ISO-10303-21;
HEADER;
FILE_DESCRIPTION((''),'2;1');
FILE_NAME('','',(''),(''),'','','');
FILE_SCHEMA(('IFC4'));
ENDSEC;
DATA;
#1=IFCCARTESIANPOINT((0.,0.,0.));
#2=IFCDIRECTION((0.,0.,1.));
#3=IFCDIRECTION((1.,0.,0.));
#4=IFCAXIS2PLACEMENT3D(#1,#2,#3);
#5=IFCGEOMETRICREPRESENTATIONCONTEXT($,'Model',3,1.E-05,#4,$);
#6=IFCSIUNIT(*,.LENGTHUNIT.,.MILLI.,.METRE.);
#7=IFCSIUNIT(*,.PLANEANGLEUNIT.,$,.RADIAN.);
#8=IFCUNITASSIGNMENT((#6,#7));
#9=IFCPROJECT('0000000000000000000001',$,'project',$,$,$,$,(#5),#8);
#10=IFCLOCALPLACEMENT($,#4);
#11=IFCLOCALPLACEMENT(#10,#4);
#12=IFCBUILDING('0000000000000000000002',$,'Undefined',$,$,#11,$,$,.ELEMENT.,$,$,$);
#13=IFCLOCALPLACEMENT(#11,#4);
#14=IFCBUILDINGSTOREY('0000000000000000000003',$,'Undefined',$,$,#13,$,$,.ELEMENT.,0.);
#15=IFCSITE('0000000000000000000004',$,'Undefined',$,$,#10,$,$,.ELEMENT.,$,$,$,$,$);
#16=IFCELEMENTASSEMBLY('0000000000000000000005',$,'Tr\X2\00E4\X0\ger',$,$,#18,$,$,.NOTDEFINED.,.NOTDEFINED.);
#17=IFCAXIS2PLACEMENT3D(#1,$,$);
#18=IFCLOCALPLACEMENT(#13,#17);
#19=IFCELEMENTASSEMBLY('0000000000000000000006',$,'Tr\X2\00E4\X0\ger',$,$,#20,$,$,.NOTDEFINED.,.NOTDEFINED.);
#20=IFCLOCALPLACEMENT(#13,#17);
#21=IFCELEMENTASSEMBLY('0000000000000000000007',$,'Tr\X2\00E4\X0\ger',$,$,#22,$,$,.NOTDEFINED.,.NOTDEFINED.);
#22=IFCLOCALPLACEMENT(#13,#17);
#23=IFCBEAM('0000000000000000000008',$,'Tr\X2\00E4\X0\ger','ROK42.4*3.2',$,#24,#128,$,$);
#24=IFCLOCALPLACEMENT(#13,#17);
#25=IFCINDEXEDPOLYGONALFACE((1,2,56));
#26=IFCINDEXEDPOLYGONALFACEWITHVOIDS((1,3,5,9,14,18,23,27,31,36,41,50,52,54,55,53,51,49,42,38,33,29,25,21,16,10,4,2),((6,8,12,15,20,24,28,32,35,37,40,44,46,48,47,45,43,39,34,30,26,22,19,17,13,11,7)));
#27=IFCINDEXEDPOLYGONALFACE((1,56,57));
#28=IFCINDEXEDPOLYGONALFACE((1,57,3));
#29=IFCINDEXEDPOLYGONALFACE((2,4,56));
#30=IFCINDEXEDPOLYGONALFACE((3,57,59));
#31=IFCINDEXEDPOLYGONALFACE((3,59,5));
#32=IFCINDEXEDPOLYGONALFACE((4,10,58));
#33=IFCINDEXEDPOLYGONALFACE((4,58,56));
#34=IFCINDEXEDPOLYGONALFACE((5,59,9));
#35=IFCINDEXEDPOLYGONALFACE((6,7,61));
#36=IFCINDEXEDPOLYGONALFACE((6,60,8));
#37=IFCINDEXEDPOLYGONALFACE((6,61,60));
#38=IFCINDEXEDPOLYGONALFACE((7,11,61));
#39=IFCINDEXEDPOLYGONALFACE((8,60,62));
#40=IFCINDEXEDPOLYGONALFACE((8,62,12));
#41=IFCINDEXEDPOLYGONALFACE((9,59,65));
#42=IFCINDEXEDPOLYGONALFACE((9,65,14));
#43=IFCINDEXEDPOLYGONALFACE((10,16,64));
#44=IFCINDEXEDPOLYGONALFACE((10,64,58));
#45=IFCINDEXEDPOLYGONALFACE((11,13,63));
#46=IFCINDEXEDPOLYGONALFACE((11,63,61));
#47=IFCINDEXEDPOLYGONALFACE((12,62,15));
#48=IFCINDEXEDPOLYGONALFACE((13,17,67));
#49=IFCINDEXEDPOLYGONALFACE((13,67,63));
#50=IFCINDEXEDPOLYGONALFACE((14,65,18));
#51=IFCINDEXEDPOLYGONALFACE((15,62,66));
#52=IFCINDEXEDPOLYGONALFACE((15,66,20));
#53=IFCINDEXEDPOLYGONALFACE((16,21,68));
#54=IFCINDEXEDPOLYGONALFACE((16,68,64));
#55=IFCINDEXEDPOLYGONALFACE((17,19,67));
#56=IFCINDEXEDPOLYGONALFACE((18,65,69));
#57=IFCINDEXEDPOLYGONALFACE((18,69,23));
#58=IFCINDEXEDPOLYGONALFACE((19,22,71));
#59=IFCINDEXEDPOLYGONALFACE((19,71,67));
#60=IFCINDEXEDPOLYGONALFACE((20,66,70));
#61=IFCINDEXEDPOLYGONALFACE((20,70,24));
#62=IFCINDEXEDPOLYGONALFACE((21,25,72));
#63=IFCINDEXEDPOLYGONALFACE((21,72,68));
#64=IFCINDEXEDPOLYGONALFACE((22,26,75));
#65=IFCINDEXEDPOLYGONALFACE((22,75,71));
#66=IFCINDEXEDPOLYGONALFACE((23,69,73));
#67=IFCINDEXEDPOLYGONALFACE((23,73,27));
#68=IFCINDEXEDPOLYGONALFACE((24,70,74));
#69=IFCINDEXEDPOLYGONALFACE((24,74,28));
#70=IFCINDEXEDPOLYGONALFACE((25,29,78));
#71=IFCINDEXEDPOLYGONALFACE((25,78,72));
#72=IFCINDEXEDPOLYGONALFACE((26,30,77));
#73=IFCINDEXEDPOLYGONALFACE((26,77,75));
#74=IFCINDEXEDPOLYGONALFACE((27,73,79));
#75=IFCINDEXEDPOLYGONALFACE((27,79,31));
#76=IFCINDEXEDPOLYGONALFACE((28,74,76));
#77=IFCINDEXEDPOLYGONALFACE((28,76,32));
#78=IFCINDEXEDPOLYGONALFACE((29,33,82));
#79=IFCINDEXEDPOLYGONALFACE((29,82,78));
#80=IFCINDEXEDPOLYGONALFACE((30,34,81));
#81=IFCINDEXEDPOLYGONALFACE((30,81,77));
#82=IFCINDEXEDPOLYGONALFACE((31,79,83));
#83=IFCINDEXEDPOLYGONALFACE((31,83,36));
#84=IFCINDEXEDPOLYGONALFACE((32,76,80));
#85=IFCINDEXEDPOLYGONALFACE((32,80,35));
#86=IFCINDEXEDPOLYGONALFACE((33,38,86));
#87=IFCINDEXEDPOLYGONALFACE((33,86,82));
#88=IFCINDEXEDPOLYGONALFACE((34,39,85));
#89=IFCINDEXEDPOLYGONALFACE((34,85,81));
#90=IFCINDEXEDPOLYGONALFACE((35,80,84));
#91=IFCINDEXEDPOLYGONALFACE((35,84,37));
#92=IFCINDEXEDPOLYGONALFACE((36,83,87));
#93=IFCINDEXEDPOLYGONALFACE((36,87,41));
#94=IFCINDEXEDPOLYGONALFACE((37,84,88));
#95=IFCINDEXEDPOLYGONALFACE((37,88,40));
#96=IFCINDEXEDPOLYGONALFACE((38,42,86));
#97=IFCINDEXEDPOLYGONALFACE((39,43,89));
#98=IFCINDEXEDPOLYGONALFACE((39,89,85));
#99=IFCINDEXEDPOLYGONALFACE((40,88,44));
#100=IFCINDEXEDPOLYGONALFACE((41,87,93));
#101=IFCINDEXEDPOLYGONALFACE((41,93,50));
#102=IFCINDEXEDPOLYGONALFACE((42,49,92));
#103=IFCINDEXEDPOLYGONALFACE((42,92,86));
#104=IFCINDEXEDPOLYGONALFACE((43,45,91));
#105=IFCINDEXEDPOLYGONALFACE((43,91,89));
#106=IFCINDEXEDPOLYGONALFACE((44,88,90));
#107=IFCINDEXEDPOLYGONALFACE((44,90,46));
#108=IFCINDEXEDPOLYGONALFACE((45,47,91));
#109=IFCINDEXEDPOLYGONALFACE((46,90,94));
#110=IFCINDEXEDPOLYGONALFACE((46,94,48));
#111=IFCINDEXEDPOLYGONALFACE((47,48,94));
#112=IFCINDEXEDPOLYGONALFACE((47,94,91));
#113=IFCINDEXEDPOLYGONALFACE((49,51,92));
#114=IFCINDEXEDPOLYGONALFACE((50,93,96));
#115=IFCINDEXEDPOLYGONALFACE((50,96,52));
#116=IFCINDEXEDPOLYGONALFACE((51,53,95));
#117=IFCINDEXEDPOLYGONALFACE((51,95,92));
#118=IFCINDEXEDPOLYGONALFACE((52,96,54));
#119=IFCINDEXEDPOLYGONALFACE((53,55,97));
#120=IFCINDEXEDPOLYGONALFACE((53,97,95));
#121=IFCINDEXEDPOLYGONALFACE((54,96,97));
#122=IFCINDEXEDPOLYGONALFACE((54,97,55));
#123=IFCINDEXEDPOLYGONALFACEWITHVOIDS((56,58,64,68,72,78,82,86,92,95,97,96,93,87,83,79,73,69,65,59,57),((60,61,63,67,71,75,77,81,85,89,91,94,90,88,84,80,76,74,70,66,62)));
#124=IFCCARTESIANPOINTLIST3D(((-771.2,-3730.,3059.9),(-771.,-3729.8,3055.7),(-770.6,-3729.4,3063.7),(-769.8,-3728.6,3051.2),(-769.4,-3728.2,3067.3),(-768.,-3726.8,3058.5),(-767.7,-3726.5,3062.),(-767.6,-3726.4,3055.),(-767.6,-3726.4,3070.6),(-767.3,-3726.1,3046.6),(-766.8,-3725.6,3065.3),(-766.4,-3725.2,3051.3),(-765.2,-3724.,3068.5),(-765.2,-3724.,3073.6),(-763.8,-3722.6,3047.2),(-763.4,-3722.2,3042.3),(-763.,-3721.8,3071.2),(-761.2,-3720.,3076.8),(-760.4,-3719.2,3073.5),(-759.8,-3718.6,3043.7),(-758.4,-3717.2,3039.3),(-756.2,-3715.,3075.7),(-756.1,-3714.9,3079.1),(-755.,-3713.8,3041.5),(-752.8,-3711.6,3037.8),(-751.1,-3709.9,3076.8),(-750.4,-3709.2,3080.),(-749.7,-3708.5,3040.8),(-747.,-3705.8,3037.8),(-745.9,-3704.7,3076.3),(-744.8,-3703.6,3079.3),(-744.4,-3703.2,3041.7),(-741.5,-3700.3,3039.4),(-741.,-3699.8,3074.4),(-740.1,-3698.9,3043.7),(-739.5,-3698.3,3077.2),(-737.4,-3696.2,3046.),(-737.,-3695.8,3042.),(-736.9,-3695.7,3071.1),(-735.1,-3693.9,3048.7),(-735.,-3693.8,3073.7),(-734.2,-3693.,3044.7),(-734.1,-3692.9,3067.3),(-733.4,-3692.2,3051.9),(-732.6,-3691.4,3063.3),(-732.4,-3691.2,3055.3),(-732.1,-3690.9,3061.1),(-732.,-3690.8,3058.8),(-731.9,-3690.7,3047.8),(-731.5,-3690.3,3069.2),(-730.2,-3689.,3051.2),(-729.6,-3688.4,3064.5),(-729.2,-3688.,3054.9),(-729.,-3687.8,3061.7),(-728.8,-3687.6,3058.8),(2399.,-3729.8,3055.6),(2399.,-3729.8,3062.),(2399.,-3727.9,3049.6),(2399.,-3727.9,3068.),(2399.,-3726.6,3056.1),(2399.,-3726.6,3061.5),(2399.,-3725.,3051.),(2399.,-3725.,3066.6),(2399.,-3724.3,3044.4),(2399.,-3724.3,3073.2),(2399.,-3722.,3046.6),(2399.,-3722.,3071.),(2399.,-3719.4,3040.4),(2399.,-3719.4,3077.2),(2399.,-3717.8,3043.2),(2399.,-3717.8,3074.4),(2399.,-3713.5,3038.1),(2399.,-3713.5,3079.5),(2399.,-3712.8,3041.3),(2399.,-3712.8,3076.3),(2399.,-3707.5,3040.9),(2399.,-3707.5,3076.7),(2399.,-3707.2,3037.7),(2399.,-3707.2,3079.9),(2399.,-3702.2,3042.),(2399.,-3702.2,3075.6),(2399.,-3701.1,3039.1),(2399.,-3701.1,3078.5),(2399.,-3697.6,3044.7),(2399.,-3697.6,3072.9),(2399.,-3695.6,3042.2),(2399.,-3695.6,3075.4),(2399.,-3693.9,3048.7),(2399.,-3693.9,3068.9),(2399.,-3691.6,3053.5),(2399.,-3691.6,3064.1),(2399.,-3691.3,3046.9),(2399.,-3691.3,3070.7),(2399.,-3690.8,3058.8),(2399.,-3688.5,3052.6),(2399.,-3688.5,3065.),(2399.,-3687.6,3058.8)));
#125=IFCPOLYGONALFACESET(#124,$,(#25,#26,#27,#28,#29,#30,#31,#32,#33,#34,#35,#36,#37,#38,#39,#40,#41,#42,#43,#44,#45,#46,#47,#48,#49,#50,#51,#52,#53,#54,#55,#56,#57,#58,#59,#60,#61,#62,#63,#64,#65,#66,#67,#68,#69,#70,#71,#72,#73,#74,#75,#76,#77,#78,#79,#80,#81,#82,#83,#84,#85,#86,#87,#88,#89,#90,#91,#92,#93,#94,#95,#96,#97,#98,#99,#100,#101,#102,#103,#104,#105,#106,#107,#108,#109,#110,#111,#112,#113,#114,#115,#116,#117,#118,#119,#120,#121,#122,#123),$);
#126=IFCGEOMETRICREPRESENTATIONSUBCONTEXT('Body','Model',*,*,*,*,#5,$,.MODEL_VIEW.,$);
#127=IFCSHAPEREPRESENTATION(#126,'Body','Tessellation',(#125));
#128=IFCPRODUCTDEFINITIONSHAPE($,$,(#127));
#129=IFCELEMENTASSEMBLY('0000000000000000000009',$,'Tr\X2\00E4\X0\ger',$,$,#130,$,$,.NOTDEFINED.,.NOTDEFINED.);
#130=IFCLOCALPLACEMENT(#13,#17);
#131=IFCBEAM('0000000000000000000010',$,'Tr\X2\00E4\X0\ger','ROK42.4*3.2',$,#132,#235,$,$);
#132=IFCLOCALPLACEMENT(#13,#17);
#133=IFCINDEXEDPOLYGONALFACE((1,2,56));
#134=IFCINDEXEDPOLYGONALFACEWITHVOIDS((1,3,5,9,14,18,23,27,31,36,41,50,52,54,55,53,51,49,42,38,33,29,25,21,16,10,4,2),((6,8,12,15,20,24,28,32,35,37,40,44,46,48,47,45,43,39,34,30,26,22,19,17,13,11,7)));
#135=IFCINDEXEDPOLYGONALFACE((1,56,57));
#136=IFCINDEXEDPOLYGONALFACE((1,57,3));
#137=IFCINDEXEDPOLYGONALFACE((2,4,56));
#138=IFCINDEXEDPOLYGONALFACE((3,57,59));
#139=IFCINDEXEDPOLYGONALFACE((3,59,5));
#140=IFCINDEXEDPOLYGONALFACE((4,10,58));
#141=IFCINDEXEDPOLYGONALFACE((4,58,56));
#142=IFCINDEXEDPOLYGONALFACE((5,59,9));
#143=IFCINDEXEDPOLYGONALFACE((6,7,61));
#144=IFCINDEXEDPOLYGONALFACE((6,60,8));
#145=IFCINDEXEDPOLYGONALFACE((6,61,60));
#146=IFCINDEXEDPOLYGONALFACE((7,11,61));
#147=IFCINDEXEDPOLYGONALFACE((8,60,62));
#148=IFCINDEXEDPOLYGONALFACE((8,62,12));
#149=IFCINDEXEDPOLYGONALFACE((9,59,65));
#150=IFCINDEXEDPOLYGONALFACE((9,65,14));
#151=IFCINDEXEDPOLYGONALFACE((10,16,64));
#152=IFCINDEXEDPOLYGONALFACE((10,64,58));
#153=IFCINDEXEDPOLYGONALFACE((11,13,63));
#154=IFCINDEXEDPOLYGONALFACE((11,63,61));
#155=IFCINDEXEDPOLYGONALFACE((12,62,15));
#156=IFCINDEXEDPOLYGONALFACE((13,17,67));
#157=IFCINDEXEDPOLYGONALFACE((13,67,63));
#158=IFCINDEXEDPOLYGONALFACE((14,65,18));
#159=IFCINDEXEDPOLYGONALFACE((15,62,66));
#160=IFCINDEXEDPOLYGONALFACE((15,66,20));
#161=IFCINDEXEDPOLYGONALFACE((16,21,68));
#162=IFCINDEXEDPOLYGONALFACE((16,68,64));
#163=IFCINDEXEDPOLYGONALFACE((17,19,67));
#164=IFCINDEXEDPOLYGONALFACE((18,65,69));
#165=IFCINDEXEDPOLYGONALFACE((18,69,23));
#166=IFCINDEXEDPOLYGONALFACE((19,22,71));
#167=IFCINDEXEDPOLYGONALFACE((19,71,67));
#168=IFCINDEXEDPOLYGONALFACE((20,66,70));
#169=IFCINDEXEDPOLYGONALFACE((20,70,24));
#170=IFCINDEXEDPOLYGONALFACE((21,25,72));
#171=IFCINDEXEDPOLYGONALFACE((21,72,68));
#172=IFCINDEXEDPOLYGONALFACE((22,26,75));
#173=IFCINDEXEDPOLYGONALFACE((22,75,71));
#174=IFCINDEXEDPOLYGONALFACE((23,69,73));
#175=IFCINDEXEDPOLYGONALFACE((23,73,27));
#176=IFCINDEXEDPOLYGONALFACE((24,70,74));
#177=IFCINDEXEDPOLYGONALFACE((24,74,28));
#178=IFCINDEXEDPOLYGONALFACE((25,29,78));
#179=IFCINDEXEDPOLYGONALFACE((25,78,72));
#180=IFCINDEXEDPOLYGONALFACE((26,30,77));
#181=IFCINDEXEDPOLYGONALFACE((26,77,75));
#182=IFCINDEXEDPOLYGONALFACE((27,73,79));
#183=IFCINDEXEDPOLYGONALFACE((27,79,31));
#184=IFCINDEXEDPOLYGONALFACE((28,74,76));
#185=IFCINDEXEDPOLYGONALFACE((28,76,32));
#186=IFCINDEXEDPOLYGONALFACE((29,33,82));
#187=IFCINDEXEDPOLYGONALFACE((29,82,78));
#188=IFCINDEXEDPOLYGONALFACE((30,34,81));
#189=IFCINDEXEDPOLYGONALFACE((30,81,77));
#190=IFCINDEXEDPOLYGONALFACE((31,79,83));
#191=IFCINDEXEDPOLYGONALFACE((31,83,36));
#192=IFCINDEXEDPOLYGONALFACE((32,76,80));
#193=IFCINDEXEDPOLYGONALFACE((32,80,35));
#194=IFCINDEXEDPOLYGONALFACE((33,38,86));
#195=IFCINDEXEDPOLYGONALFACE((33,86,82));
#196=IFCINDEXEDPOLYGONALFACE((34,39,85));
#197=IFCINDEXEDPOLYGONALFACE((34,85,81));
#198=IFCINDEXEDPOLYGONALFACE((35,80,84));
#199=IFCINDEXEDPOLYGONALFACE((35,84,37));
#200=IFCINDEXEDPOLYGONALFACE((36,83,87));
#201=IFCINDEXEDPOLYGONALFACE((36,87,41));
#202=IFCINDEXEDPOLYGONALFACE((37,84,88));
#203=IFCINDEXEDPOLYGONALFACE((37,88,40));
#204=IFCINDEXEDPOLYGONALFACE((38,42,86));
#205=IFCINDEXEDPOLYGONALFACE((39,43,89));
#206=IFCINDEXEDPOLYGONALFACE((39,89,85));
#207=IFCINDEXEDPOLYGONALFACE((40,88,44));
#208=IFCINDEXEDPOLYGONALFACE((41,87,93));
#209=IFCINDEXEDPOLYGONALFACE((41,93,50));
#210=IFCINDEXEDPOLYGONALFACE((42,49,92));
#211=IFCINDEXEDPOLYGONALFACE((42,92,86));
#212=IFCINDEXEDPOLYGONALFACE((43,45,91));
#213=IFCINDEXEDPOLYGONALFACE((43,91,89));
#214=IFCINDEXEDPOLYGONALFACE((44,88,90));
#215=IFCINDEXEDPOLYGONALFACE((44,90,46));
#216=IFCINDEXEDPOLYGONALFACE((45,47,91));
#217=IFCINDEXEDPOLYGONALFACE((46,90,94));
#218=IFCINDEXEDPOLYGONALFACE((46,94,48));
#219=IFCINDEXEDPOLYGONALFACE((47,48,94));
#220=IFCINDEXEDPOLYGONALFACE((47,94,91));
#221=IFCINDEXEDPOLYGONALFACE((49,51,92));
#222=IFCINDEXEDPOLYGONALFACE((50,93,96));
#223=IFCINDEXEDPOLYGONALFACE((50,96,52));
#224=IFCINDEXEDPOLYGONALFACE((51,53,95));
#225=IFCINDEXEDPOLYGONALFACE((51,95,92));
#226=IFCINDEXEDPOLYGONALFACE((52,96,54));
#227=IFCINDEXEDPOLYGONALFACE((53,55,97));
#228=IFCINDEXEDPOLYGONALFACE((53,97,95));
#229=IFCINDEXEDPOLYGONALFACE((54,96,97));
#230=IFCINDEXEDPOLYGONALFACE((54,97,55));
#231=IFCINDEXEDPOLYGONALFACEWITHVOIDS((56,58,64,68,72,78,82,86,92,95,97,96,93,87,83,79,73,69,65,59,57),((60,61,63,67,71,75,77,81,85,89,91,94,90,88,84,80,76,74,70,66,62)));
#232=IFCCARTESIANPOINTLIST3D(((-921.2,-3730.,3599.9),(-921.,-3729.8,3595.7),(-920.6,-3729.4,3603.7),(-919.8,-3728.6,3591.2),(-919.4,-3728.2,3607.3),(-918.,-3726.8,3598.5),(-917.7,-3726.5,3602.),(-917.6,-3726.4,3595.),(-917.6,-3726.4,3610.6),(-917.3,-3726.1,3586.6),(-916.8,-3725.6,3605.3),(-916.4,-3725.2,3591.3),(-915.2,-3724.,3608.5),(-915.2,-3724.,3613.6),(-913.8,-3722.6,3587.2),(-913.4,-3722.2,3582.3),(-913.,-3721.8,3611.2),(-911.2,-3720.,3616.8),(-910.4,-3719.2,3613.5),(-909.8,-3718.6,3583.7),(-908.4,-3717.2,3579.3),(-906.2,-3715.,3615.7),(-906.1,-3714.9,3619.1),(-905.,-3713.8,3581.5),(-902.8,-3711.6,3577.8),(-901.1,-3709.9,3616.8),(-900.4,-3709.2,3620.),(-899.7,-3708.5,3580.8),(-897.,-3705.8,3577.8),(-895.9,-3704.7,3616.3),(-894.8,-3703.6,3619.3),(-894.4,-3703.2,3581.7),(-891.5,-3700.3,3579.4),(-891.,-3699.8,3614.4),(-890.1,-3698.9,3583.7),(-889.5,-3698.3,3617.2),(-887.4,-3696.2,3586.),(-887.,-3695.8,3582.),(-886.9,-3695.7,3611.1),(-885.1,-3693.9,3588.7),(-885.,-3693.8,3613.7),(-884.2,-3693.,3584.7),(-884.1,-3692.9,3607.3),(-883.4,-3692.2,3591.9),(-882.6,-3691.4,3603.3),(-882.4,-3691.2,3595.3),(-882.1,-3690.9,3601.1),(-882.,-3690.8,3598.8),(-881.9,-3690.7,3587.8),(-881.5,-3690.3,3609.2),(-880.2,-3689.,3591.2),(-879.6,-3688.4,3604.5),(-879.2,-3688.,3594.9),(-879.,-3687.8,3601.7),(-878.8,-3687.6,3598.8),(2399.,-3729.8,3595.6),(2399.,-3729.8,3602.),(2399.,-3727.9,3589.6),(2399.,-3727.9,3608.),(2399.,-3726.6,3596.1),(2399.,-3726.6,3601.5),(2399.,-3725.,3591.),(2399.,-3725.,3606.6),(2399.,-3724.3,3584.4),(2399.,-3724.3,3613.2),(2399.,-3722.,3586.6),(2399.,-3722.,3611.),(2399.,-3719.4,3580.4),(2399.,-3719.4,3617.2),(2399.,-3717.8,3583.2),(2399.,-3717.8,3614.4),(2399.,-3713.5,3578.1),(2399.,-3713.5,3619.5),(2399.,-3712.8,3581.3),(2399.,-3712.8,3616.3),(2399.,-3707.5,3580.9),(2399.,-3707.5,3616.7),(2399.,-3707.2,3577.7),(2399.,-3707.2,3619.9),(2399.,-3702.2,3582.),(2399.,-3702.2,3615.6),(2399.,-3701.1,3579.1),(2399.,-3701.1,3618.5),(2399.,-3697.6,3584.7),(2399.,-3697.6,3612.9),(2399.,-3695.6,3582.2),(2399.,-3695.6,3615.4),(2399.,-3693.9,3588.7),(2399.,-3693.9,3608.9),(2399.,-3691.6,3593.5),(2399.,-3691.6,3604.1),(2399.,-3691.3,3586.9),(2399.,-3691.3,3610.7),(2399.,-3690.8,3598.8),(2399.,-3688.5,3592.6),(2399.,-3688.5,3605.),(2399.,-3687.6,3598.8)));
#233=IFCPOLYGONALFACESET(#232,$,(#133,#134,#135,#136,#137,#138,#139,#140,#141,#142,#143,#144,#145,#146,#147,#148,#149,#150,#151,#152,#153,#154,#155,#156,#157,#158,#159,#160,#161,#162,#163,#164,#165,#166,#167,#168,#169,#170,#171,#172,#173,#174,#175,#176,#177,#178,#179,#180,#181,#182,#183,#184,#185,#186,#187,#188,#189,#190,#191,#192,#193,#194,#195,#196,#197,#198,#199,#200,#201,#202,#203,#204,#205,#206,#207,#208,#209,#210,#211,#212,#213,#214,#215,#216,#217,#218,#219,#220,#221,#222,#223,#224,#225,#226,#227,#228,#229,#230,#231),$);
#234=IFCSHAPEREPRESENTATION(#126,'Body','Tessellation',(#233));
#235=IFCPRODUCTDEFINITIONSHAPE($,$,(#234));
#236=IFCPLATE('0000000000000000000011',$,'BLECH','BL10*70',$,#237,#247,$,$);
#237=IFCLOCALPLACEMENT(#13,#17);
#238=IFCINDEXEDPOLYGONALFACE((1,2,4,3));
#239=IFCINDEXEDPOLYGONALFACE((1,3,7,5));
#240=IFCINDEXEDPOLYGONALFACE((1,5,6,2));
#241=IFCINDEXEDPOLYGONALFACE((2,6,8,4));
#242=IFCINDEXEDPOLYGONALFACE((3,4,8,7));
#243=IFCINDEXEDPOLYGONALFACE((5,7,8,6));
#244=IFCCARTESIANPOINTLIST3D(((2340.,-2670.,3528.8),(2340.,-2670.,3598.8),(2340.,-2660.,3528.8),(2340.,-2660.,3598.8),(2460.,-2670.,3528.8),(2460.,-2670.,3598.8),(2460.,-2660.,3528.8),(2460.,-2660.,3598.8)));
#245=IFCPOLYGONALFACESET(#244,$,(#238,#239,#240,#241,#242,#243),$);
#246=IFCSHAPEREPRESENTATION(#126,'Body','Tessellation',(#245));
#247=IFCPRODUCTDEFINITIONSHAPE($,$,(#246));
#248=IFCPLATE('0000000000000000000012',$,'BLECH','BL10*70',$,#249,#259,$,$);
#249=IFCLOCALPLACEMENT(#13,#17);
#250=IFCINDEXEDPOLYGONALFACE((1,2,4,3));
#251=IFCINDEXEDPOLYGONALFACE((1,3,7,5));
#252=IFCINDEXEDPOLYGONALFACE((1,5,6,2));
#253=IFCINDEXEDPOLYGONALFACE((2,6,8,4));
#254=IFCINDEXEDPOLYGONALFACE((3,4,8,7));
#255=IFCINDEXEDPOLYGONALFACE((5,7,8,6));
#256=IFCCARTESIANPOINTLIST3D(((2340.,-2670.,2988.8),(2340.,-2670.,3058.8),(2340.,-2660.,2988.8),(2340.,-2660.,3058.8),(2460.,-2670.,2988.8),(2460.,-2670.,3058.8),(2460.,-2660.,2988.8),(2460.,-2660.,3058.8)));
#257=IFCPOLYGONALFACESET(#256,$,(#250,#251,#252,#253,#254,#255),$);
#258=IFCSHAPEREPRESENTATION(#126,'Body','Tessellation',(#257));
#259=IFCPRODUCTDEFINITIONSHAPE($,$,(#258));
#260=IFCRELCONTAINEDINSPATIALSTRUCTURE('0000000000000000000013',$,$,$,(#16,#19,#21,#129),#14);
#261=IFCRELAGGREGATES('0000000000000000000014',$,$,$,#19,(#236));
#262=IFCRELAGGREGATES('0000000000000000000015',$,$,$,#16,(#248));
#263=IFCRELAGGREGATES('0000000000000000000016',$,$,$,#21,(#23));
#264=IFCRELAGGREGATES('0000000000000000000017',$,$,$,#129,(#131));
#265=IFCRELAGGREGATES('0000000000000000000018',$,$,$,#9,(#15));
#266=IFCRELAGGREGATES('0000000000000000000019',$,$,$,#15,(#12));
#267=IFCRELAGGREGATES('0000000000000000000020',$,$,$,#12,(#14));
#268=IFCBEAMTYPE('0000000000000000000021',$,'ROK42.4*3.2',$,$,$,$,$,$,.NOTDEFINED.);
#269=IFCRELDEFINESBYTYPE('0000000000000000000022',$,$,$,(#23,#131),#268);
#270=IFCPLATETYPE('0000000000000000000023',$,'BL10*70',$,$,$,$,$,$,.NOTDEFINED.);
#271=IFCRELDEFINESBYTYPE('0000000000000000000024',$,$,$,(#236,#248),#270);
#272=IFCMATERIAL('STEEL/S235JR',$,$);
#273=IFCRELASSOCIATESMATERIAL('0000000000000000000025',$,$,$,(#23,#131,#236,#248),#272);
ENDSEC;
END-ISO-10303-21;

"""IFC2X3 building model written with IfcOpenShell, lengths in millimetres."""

from ifc_helpers import new_model, si_unit, frame, origin_with_axes, origin_2d_with_axis, place, context, subcontext, project, spatial, polyline, hollow_circle, outline, extrude, clip, halfspace, material, type_object, element, aggregate, save


model = new_model("IFC2X3")

# Units and contexts
model_context = context("Model", 3, precision=1e-05, world=origin_with_axes())
body_context = subcontext(model_context, "Body", "Model", "MODEL_VIEW")
ifc_project = project(units=[si_unit("LENGTHUNIT", "METRE", prefix="MILLI"), si_unit("PLANEANGLEUNIT", "RADIAN")], contexts=[model_context])

# Site, building, storey
site_placement = place(None, origin_with_axes())
site = spatial("IfcSite", under=ifc_project, at=site_placement, Name="Undefined", CompositionType="ELEMENT")
building_placement = place(site_placement, origin_with_axes())
building = spatial("IfcBuilding", under=site, at=building_placement, Name="Undefined", CompositionType="ELEMENT")
storey_placement = place(building_placement, origin_with_axes())
storey = spatial("IfcBuildingStorey", under=building, at=storey_placement, Name="Undefined", CompositionType="ELEMENT", Elevation=0.0)

# Element assemblies
assembly_1_placement = place(storey_placement, origin_with_axes())
assembly_1 = element("IfcElementAssembly", 1, at=assembly_1_placement, inside=storey, Name="Träger", AssemblyPlace="NOTDEFINED", PredefinedType="NOTDEFINED")
ifc_material_1 = material(Name="STEEL/S235JR")
beam_type = type_object("IfcBeamType", Name="ROK42.4*3.2", PredefinedType="NOTDEFINED")
assembly_2_placement = place(storey_placement, origin_with_axes())
assembly_2 = element("IfcElementAssembly", 2, at=assembly_2_placement, inside=storey, Name="Träger", AssemblyPlace="NOTDEFINED", PredefinedType="NOTDEFINED")

# Element assemblies, beams
assembly_3_placement = place(storey_placement, origin_with_axes())
assembly_3 = element("IfcElementAssembly", 3, at=assembly_3_placement, inside=storey, Name="Träger", AssemblyPlace="NOTDEFINED", PredefinedType="NOTDEFINED")
beam_1_placement = place(assembly_3_placement, frame((2399.0, -3708.8, 3058.8), z_axis=(0.0, 0.0, 1.0), x_axis=(-1.0, 0.0, 0.0)))
beam_1 = element("IfcBeam", 4, at=beam_1_placement, type_object=beam_type, material=ifc_material_1, Name="Träger", Description="ROK42.4*3.2", context=body_context, shape_type="Clipping", body=[
    clip(extrude(hollow_circle(Radius=21.2, WallThickness=3.2, at=origin_2d_with_axis()), frame((3170.4, 0.0, 0.0), z_axis=(-1.0, 0.0, 0.0), x_axis=(0.0, -1.0, 0.0)), (0.0, 0.0, 1.0), 3170.4), halfspace(frame((3127.8, -21.2, 0.0), z_axis=(0.707107, -0.707107, 0.0), x_axis=(0.0, 0.0, 1.0)), False)),
])
assembly_4_placement = place(storey_placement, origin_with_axes())
assembly_4 = element("IfcElementAssembly", 5, at=assembly_4_placement, inside=storey, Name="Träger", AssemblyPlace="NOTDEFINED", PredefinedType="NOTDEFINED")
beam_2_placement = place(assembly_4_placement, frame((2399.0, -3708.8, 3598.8), z_axis=(0.0, 0.0, 1.0), x_axis=(-1.0, 0.0, 0.0)))
beam_2 = element("IfcBeam", 6, at=beam_2_placement, type_object=beam_type, material=ifc_material_1, Name="Träger", Description="ROK42.4*3.2", context=body_context, shape_type="Clipping", body=[
    clip(extrude(hollow_circle(Radius=21.2, WallThickness=3.2, at=origin_2d_with_axis()), frame((3320.4, 0.0, 0.0), z_axis=(-1.0, 0.0, 0.0), x_axis=(0.0, -1.0, 0.0)), (0.0, 0.0, 1.0), 3320.4), halfspace(frame((3277.8, -21.2, 0.0), z_axis=(0.707107, -0.707107, 0.0), x_axis=(0.0, 0.0, 1.0)), False)),
])

# Plates
plate_type_1 = type_object("IfcPlateType", Name="BL10*70", PredefinedType="NOTDEFINED")
plate_1_placement = place(assembly_2_placement, frame((2460.0, -2665.0, 3598.8), z_axis=(0.0, -1.0, 0.0), x_axis=(-1.0, 0.0, 0.0)))
plate_1 = element("IfcPlate", 7, at=plate_1_placement, type_object=plate_type_1, material=ifc_material_1, Name="BLECH", Description="BL10*70", context=body_context, shape_type="SweptSolid", body=[
    extrude(outline(polyline([(0.0, 0.0), (120.0, 0.0), (120.0, 70.0), (0.0, 70.0), (0.0, 0.0)])), frame((0.0, 0.0, -5.0), z_axis=(0.0, 0.0, 1.0), x_axis=(1.0, 0.0, 0.0)), (0.0, 0.0, 1.0), 10.0),
])
aggregate(assembly_2, [plate_1])
plate_2_placement = place(assembly_1_placement, frame((2460.0, -2665.0, 3058.8), z_axis=(0.0, -1.0, 0.0), x_axis=(-1.0, 0.0, 0.0)))
plate_2 = element("IfcPlate", 8, at=plate_2_placement, type_object=plate_type_1, material=ifc_material_1, Name="BLECH", Description="BL10*70", context=body_context, shape_type="SweptSolid", body=[
    extrude(outline(polyline([(0.0, 0.0), (120.0, 0.0), (120.0, 70.0), (0.0, 70.0), (0.0, 0.0)])), frame((0.0, 0.0, -5.0), z_axis=(0.0, 0.0, 1.0), x_axis=(1.0, 0.0, 0.0)), (0.0, 0.0, 1.0), 10.0),
])
aggregate(assembly_1, [plate_2])
aggregate(assembly_3, [beam_1])
aggregate(assembly_4, [beam_2])

save(model, "model.ifc")
